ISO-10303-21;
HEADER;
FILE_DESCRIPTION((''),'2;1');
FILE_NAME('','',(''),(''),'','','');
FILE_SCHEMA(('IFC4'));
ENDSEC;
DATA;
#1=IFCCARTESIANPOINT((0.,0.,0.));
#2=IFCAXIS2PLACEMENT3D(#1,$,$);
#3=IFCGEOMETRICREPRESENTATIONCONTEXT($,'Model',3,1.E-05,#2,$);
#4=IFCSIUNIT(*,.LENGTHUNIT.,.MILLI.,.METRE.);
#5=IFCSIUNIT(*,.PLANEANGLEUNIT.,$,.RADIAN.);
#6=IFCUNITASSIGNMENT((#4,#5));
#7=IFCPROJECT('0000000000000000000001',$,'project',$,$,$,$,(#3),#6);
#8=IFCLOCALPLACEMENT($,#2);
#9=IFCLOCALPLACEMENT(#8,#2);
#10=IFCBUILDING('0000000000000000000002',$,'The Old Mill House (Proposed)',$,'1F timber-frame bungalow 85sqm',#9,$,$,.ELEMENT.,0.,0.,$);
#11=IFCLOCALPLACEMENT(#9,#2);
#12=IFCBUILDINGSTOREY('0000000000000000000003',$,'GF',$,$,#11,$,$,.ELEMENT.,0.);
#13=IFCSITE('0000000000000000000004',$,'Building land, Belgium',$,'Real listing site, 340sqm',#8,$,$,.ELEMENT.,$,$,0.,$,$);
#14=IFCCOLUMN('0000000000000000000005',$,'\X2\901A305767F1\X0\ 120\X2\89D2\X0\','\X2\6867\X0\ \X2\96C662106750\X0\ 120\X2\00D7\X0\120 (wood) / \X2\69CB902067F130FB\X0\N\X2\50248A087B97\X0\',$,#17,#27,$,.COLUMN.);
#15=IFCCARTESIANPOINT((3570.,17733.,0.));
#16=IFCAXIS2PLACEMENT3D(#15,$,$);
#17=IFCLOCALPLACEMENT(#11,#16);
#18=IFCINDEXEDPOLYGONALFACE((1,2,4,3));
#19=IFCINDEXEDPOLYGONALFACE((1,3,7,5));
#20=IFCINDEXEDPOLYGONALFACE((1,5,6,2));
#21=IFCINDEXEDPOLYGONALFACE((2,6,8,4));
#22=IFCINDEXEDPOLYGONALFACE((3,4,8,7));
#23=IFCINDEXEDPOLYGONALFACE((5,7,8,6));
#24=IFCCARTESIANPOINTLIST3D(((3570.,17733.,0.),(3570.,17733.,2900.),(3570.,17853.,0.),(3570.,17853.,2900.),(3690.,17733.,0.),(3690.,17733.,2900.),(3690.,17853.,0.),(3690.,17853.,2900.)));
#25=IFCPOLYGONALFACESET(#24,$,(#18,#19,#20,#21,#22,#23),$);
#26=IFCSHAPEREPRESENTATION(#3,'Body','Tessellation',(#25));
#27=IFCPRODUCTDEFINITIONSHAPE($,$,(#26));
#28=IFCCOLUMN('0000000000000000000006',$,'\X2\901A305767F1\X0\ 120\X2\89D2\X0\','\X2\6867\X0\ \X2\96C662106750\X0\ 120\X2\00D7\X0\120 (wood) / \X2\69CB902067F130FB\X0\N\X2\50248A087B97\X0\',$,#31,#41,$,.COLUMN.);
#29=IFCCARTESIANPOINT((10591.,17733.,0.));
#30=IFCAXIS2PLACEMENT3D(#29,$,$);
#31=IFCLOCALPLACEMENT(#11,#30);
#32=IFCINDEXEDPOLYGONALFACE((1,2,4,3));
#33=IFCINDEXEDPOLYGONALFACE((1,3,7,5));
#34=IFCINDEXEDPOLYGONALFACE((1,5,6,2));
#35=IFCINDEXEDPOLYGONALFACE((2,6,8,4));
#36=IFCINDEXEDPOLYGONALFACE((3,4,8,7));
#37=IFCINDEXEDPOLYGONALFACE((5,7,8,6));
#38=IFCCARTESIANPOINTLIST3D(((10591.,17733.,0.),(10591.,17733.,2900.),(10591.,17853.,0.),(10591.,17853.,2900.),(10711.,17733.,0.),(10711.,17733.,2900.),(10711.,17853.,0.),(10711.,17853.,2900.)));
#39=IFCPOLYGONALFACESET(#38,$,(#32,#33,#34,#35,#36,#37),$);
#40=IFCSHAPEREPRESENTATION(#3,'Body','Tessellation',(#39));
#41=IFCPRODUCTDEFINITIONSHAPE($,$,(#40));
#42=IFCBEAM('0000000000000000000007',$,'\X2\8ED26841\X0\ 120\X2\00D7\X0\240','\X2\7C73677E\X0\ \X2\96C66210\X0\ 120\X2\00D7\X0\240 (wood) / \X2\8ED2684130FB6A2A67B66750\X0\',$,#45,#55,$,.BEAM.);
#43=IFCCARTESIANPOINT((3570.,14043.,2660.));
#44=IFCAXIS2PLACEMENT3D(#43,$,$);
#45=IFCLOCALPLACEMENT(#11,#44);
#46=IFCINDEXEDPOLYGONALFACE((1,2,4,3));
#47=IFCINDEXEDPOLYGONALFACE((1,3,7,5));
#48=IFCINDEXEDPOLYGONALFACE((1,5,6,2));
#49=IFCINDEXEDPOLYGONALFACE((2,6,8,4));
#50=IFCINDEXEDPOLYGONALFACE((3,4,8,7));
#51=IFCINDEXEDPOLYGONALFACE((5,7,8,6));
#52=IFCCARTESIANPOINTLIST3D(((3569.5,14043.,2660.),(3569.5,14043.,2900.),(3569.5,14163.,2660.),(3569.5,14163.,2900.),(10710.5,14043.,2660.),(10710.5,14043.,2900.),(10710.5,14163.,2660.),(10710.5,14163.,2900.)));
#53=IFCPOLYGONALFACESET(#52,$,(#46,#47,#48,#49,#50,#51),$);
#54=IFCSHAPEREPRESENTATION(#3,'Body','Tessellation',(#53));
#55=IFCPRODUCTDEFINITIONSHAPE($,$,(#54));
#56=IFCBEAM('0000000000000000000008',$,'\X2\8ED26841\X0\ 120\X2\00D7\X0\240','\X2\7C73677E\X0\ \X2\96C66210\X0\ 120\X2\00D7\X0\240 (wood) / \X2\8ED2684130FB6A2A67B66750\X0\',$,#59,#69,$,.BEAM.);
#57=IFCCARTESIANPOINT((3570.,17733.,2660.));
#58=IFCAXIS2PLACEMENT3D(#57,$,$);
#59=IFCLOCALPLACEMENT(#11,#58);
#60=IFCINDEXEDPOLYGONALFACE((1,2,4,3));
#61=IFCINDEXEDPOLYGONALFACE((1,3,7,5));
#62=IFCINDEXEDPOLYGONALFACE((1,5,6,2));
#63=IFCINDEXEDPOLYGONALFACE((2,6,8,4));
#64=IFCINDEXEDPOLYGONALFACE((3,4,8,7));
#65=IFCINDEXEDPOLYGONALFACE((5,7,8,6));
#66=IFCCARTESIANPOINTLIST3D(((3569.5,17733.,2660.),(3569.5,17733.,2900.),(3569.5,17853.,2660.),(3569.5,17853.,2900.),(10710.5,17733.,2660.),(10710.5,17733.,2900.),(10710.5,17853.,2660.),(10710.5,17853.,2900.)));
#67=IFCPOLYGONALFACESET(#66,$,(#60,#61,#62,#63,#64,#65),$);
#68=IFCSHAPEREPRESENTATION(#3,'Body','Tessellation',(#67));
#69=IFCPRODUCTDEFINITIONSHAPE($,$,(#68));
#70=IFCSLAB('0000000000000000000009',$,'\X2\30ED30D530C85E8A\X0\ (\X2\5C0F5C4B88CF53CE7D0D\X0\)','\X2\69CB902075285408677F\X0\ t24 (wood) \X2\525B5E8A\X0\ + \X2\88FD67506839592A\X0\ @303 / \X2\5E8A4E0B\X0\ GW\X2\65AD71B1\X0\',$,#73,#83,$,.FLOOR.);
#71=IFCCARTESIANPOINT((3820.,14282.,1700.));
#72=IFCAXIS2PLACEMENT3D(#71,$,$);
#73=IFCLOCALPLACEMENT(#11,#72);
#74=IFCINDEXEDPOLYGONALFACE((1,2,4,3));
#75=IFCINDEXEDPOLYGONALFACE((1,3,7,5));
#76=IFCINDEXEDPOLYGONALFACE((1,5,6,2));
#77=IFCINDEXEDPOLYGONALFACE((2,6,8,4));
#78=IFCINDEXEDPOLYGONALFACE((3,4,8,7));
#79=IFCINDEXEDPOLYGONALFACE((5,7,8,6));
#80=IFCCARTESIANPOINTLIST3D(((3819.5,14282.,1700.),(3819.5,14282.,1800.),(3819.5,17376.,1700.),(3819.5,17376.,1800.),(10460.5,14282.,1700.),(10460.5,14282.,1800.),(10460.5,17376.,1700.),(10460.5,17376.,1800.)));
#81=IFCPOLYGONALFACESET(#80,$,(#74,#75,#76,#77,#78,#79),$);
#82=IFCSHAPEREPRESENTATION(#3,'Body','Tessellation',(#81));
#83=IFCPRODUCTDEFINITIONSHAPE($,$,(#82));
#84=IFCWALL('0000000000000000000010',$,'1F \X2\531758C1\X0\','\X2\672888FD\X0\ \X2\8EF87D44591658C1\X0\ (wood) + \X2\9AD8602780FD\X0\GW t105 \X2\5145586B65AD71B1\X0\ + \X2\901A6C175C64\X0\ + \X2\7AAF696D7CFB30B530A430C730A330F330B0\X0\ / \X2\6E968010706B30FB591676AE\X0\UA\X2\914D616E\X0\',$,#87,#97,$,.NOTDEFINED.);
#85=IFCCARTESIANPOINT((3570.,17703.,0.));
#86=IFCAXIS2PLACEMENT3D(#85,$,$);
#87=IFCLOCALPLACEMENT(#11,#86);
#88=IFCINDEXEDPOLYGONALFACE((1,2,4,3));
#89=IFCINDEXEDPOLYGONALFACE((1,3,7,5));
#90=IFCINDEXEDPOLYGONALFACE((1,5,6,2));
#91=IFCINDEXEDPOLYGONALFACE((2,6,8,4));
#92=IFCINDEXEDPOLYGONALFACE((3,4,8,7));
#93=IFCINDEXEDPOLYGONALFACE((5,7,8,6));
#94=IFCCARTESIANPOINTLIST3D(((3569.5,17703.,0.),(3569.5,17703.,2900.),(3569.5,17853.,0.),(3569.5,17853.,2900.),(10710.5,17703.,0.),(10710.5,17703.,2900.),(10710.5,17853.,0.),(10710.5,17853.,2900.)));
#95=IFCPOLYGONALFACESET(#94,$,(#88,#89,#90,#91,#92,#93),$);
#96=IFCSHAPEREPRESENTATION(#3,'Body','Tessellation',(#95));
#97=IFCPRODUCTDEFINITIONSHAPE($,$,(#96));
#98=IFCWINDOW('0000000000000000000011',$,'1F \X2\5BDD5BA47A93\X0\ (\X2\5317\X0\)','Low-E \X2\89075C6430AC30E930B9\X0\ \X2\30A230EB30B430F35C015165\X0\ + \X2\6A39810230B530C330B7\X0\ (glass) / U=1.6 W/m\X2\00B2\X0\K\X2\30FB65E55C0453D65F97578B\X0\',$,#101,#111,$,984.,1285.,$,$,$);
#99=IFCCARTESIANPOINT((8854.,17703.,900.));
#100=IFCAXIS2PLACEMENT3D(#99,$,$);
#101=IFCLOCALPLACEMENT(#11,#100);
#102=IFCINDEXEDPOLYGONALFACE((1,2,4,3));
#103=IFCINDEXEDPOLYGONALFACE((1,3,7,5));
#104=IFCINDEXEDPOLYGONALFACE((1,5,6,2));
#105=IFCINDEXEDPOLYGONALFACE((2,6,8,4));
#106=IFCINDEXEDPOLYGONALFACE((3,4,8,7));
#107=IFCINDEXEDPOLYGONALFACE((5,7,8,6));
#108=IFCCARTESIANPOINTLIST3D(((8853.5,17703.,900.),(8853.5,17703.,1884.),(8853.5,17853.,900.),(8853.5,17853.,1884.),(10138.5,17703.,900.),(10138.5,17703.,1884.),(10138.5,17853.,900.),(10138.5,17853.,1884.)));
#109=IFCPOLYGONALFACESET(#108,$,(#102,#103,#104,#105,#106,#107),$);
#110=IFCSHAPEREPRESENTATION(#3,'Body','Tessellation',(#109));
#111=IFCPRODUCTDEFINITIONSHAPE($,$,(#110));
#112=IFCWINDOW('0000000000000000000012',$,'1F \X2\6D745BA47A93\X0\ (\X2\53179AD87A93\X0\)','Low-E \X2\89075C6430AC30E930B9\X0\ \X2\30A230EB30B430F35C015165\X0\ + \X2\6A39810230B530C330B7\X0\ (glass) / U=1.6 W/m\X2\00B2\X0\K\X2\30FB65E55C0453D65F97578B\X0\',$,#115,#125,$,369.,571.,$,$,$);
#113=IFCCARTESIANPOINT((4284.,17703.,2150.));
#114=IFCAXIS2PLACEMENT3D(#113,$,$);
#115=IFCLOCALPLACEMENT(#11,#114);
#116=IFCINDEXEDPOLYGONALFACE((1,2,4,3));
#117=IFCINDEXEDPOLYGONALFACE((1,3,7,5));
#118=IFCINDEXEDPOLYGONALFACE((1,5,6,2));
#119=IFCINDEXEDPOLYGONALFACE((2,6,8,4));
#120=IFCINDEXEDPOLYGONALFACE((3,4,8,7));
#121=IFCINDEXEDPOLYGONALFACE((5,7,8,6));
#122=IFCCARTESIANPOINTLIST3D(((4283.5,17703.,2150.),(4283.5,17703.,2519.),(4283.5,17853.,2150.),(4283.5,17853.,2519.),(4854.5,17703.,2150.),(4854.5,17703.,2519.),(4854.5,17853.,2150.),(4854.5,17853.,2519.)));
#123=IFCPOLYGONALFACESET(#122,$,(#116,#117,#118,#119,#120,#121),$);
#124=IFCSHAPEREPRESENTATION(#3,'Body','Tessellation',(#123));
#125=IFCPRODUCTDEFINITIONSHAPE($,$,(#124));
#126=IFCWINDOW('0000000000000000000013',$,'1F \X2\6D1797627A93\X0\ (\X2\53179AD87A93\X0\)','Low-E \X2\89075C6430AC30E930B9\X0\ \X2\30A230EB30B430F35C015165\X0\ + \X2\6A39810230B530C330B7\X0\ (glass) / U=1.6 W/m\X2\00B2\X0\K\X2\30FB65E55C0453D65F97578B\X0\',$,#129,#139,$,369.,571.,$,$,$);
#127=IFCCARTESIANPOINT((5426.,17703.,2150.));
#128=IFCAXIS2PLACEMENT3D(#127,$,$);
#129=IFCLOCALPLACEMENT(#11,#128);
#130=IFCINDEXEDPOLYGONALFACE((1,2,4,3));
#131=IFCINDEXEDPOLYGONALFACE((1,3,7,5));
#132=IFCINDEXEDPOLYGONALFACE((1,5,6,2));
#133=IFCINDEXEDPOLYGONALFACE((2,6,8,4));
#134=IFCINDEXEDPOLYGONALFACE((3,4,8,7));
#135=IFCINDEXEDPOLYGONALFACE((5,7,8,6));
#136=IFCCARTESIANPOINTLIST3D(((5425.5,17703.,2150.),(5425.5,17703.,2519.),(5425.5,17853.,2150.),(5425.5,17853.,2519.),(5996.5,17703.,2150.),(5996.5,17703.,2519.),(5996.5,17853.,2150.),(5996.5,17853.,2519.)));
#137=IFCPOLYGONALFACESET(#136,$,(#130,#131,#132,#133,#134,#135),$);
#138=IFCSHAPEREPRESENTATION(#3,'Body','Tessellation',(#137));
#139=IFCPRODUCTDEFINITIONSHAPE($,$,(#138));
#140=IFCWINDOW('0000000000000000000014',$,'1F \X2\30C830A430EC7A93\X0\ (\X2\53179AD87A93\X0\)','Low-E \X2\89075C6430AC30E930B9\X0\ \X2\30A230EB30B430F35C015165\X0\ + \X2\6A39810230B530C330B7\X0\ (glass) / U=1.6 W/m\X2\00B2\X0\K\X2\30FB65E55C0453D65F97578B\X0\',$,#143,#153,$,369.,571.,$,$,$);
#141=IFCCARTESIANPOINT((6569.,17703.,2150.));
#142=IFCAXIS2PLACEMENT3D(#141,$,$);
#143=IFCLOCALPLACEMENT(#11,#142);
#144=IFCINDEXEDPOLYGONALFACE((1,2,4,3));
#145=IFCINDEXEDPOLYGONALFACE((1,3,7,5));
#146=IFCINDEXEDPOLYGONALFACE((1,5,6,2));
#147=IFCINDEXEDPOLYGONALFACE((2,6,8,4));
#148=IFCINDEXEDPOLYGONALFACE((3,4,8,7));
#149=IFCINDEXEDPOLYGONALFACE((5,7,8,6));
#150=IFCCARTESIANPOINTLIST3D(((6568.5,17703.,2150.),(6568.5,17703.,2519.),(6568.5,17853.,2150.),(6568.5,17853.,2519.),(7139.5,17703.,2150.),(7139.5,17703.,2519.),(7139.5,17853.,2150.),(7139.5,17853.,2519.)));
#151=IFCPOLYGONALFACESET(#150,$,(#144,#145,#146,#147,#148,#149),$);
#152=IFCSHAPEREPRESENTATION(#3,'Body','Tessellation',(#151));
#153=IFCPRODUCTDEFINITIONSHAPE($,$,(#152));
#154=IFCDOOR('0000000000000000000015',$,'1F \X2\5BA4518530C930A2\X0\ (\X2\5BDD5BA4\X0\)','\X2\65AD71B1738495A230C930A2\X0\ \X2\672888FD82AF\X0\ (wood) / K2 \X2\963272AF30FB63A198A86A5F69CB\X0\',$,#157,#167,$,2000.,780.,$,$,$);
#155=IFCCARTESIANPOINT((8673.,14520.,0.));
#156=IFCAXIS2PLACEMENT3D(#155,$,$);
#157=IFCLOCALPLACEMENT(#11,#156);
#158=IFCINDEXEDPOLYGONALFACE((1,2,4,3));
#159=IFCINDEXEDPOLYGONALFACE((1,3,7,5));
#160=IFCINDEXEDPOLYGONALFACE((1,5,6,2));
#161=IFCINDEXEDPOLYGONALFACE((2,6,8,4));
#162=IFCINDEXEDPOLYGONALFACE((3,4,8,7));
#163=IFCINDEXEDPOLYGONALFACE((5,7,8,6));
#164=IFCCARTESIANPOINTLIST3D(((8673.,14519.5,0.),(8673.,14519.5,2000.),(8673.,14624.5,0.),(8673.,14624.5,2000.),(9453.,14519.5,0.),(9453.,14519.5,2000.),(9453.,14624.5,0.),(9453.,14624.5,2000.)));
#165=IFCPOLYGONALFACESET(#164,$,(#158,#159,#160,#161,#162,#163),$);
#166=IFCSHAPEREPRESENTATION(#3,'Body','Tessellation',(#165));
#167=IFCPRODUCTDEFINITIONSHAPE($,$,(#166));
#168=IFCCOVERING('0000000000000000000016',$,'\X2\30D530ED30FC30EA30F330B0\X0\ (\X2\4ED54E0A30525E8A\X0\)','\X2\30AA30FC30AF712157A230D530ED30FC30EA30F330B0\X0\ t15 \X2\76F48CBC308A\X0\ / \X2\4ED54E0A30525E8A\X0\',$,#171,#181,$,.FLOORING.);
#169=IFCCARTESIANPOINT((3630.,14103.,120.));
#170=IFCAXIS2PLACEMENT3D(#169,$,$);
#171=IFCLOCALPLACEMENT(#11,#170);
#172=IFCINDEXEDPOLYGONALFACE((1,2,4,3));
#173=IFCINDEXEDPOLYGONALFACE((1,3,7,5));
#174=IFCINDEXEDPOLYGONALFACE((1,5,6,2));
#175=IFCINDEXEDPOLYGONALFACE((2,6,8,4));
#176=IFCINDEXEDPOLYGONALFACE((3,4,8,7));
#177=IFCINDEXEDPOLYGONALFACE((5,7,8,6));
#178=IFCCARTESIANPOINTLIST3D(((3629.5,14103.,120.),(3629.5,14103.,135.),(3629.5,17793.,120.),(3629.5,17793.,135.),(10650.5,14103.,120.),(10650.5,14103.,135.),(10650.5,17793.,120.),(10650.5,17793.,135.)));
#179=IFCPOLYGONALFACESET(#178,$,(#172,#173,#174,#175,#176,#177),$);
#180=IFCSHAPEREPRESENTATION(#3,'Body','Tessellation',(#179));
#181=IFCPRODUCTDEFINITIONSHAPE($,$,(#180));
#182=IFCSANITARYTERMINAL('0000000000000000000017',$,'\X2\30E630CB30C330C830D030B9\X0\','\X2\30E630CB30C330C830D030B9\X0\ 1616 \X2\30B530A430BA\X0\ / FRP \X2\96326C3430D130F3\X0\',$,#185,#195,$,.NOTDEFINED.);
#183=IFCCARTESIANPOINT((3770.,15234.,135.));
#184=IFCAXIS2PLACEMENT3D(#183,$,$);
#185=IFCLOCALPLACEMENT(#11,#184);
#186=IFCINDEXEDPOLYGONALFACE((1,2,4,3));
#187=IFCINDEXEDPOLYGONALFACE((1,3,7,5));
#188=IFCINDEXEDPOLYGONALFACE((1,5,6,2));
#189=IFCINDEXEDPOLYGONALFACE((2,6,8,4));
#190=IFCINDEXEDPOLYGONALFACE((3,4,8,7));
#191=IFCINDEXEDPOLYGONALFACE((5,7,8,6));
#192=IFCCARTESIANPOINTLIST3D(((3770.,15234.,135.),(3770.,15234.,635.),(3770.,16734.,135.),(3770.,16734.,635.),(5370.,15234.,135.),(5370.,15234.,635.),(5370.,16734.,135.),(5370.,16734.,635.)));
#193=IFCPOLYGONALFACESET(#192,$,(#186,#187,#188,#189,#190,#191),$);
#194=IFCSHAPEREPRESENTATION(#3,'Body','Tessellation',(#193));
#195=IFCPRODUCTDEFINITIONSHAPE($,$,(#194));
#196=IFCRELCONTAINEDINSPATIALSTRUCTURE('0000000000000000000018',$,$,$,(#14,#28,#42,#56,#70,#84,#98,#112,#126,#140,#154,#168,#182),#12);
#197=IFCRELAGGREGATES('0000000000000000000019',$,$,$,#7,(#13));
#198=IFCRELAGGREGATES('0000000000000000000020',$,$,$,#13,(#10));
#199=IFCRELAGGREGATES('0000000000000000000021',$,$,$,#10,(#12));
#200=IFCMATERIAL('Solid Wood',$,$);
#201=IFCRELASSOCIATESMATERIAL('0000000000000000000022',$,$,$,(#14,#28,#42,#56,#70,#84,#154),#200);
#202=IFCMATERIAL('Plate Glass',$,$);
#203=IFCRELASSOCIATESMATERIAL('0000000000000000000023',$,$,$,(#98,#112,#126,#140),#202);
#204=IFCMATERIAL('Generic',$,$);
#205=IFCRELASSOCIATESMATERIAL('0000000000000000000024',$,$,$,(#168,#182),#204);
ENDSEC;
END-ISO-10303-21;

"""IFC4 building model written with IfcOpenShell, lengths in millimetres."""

from ifc_helpers import new_model, si_unit, frame, frame_2d, origin, place, context, project, spatial, rectangle, extrude, material, element, fill, save


model = new_model("IFC4")

# Units and contexts
model_context = context("Model", 3, precision=1e-05, world=origin())
ifc_project = project(units=[si_unit("LENGTHUNIT", "METRE", prefix="MILLI"), si_unit("PLANEANGLEUNIT", "RADIAN")], contexts=[model_context])

# Site, building, storey
site_placement = place(None, origin())
site = spatial("IfcSite", under=ifc_project, at=site_placement, Name="Building land, Belgium", ObjectType="Real listing site, 340sqm", CompositionType="ELEMENT", RefElevation=0.0)
building_placement = place(site_placement, origin())
building = spatial("IfcBuilding", under=site, at=building_placement, Name="The Old Mill House (Proposed)", ObjectType="1F timber-frame bungalow 85sqm", CompositionType="ELEMENT", ElevationOfRefHeight=0.0, ElevationOfTerrain=0.0)
storey_placement = place(building_placement, origin())
storey = spatial("IfcBuildingStorey", under=building, at=storey_placement, Name="GF", CompositionType="ELEMENT", Elevation=0.0)

# Columns
ifc_material_1 = material(Name="Solid Wood")
column_1_placement = place(storey_placement, frame((3570.0, 17733.0, 0.0)))
element("IfcColumn", 1, at=column_1_placement, inside=storey, material=ifc_material_1, Name="通し柱 120角", Description="桧 集成材 120×120 (wood) / 構造柱・N値計算", PredefinedType="COLUMN", context=model_context, shape_type="SweptSolid", body=[
    extrude(rectangle(XDim=120.0, YDim=120.0, at=frame_2d((60.0, 60.0))), frame((3570.0, 17733.0, 0.0)), (0.0, 0.0, 1.0), 2900.0),
])
column_2_placement = place(storey_placement, frame((10591.0, 17733.0, 0.0)))
element("IfcColumn", 2, at=column_2_placement, inside=storey, material=ifc_material_1, Name="通し柱 120角", Description="桧 集成材 120×120 (wood) / 構造柱・N値計算", PredefinedType="COLUMN", context=model_context, shape_type="SweptSolid", body=[
    extrude(rectangle(XDim=120.0, YDim=120.0, at=frame_2d((60.0, 60.0))), frame((10591.0, 17733.0, 0.0)), (0.0, 0.0, 1.0), 2900.0),
])

# Beams
beam_1_placement = place(storey_placement, frame((3570.0, 14043.0, 2660.0)))
element("IfcBeam", 3, at=beam_1_placement, inside=storey, material=ifc_material_1, Name="軒桁 120×240", Description="米松 集成 120×240 (wood) / 軒桁・横架材", PredefinedType="BEAM", context=model_context, shape_type="SweptSolid", body=[
    extrude(rectangle(XDim=7141.0, YDim=120.0, at=frame_2d((3570.0, 60.0))), frame((3570.0, 14043.0, 2660.0)), (0.0, 0.0, 1.0), 240.0),
])
beam_2_placement = place(storey_placement, frame((3570.0, 17733.0, 2660.0)))
element("IfcBeam", 4, at=beam_2_placement, inside=storey, material=ifc_material_1, Name="軒桁 120×240", Description="米松 集成 120×240 (wood) / 軒桁・横架材", PredefinedType="BEAM", context=model_context, shape_type="SweptSolid", body=[
    extrude(rectangle(XDim=7141.0, YDim=120.0, at=frame_2d((3570.0, 60.0))), frame((3570.0, 17733.0, 2660.0)), (0.0, 0.0, 1.0), 240.0),
])

# Slab
slab_placement = place(storey_placement, frame((3820.0, 14282.0, 1700.0)))
element("IfcSlab", 5, at=slab_placement, inside=storey, material=ifc_material_1, Name="ロフト床 (小屋裏収納)", Description="構造用合板 t24 (wood) 剛床 + 製材根太 @303 / 床下 GW断熱", PredefinedType="FLOOR", context=model_context, shape_type="SweptSolid", body=[
    extrude(rectangle(XDim=6641.0, YDim=3094.0, at=frame_2d((3320.0, 1547.0))), frame((3820.0, 14282.0, 1700.0)), (0.0, 0.0, 1.0), 100.0),
])

# Wall, openings, windows
wall_1_placement = place(storey_placement, frame((3570.0, 17703.0, 0.0)))
wall_1 = element("IfcWall", 6, at=wall_1_placement, inside=storey, material=ifc_material_1, Name="1F 北壁", Description="木製 軸組外壁 (wood) + 高性能GW t105 充填断熱 + 通気層 + 窯業系サイディング / 準耐火・外皮UA配慮", PredefinedType="NOTDEFINED", context=model_context, shape_type="SweptSolid", body=[
    extrude(rectangle(XDim=7141.0, YDim=150.0, at=frame_2d((3570.0, 75.0))), frame((3570.0, 17703.0, 0.0)), (0.0, 0.0, 1.0), 2900.0),
])
opening_1_placement = place(storey_placement, frame((8854.0, 17703.0, 900.0)))
opening_1 = element("IfcOpeningElement", 7, at=opening_1_placement, cuts=wall_1, PredefinedType="NOTDEFINED", context=model_context, shape_type="SweptSolid", body=[
    extrude(rectangle(XDim=1285.0, YDim=150.0, at=frame_2d((642.0, 75.0))), frame((8854.0, 17703.0, 900.0)), (0.0, 0.0, 1.0), 984.0),
])
opening_2_placement = place(storey_placement, frame((4284.0, 17703.0, 2150.0)))
opening_2 = element("IfcOpeningElement", 8, at=opening_2_placement, cuts=wall_1, PredefinedType="NOTDEFINED", context=model_context, shape_type="SweptSolid", body=[
    extrude(rectangle(XDim=571.0, YDim=150.0, at=frame_2d((285.0, 75.0))), frame((4284.0, 17703.0, 2150.0)), (0.0, 0.0, 1.0), 369.0),
])
opening_3_placement = place(storey_placement, frame((5426.0, 17703.0, 2150.0)))
opening_3 = element("IfcOpeningElement", 9, at=opening_3_placement, cuts=wall_1, PredefinedType="NOTDEFINED", context=model_context, shape_type="SweptSolid", body=[
    extrude(rectangle(XDim=571.0, YDim=150.0, at=frame_2d((285.0, 75.0))), frame((5426.0, 17703.0, 2150.0)), (0.0, 0.0, 1.0), 369.0),
])
opening_4_placement = place(storey_placement, frame((6569.0, 17703.0, 2150.0)))
opening_4 = element("IfcOpeningElement", 10, at=opening_4_placement, cuts=wall_1, PredefinedType="NOTDEFINED", context=model_context, shape_type="SweptSolid", body=[
    extrude(rectangle(XDim=571.0, YDim=150.0, at=frame_2d((285.0, 75.0))), frame((6569.0, 17703.0, 2150.0)), (0.0, 0.0, 1.0), 369.0),
])
ifc_material_2 = material(Name="Plate Glass")
window_1_placement = place(storey_placement, frame((8854.0, 17703.0, 900.0)))
window_1 = element("IfcWindow", 11, at=window_1_placement, inside=storey, material=ifc_material_2, Name="1F 寝室窓 (北)", Description="Low-E 複層ガラス アルゴン封入 + 樹脂サッシ (glass) / U=1.6 W/m²K・日射取得型", OverallHeight=984.0, OverallWidth=1285.0, context=model_context, shape_type="SweptSolid", body=[
    extrude(rectangle(XDim=1285.0, YDim=150.0, at=frame_2d((642.0, 75.0))), frame((8854.0, 17703.0, 900.0)), (0.0, 0.0, 1.0), 984.0),
])
fill(opening_1, window_1)
window_2_placement = place(storey_placement, frame((4284.0, 17703.0, 2150.0)))
window_2 = element("IfcWindow", 12, at=window_2_placement, inside=storey, material=ifc_material_2, Name="1F 浴室窓 (北高窓)", Description="Low-E 複層ガラス アルゴン封入 + 樹脂サッシ (glass) / U=1.6 W/m²K・日射取得型", OverallHeight=369.0, OverallWidth=571.0, context=model_context, shape_type="SweptSolid", body=[
    extrude(rectangle(XDim=571.0, YDim=150.0, at=frame_2d((285.0, 75.0))), frame((4284.0, 17703.0, 2150.0)), (0.0, 0.0, 1.0), 369.0),
])
fill(opening_2, window_2)
window_3_placement = place(storey_placement, frame((5426.0, 17703.0, 2150.0)))
window_3 = element("IfcWindow", 13, at=window_3_placement, inside=storey, material=ifc_material_2, Name="1F 洗面窓 (北高窓)", Description="Low-E 複層ガラス アルゴン封入 + 樹脂サッシ (glass) / U=1.6 W/m²K・日射取得型", OverallHeight=369.0, OverallWidth=571.0, context=model_context, shape_type="SweptSolid", body=[
    extrude(rectangle(XDim=571.0, YDim=150.0, at=frame_2d((285.0, 75.0))), frame((5426.0, 17703.0, 2150.0)), (0.0, 0.0, 1.0), 369.0),
])
fill(opening_3, window_3)
window_4_placement = place(storey_placement, frame((6569.0, 17703.0, 2150.0)))
window_4 = element("IfcWindow", 14, at=window_4_placement, inside=storey, material=ifc_material_2, Name="1F トイレ窓 (北高窓)", Description="Low-E 複層ガラス アルゴン封入 + 樹脂サッシ (glass) / U=1.6 W/m²K・日射取得型", OverallHeight=369.0, OverallWidth=571.0, context=model_context, shape_type="SweptSolid", body=[
    extrude(rectangle(XDim=571.0, YDim=150.0, at=frame_2d((285.0, 75.0))), frame((6569.0, 17703.0, 2150.0)), (0.0, 0.0, 1.0), 369.0),
])
fill(opening_4, window_4)

# Door
door_1_placement = place(storey_placement, frame((8673.0, 14520.0, 0.0)))
element("IfcDoor", 15, at=door_1_placement, inside=storey, material=ifc_material_1, Name="1F 室内ドア (寝室)", Description="断熱玄関ドア 木製芯 (wood) / K2 防犯・採風機構", OverallHeight=2000.0, OverallWidth=780.0, context=model_context, shape_type="SweptSolid", body=[
    extrude(rectangle(XDim=780.0, YDim=105.0, at=frame_2d((390.0, 52.0))), frame((8673.0, 14520.0, 0.0)), (0.0, 0.0, 1.0), 2000.0),
])

# Covering
ifc_material_3 = material(Name="Generic")
covering_placement = place(storey_placement, frame((3630.0, 14103.0, 120.0)))
element("IfcCovering", 16, at=covering_placement, inside=storey, material=ifc_material_3, Name="フローリング (仕上げ床)", Description="オーク無垢フローリング t15 直貼り / 仕上げ床", PredefinedType="FLOORING", context=model_context, shape_type="SweptSolid", body=[
    extrude(rectangle(XDim=7021.0, YDim=3690.0, at=frame_2d((3510.0, 1845.0))), frame((3630.0, 14103.0, 120.0)), (0.0, 0.0, 1.0), 15.0),
])

# Sanitary terminal
sanitary_terminal_1_placement = place(storey_placement, frame((3770.0, 15234.0, 135.0)))
element("IfcSanitaryTerminal", 17, at=sanitary_terminal_1_placement, inside=storey, material=ifc_material_3, Name="ユニットバス", Description="ユニットバス 1616 サイズ / FRP 防水パン", PredefinedType="NOTDEFINED", context=model_context, shape_type="SweptSolid", body=[
    extrude(rectangle(XDim=1600.0, YDim=1500.0, at=frame_2d((800.0, 750.0))), frame((3770.0, 15234.0, 135.0)), (0.0, 0.0, 1.0), 500.0),
])

save(model, "model.ifc")
